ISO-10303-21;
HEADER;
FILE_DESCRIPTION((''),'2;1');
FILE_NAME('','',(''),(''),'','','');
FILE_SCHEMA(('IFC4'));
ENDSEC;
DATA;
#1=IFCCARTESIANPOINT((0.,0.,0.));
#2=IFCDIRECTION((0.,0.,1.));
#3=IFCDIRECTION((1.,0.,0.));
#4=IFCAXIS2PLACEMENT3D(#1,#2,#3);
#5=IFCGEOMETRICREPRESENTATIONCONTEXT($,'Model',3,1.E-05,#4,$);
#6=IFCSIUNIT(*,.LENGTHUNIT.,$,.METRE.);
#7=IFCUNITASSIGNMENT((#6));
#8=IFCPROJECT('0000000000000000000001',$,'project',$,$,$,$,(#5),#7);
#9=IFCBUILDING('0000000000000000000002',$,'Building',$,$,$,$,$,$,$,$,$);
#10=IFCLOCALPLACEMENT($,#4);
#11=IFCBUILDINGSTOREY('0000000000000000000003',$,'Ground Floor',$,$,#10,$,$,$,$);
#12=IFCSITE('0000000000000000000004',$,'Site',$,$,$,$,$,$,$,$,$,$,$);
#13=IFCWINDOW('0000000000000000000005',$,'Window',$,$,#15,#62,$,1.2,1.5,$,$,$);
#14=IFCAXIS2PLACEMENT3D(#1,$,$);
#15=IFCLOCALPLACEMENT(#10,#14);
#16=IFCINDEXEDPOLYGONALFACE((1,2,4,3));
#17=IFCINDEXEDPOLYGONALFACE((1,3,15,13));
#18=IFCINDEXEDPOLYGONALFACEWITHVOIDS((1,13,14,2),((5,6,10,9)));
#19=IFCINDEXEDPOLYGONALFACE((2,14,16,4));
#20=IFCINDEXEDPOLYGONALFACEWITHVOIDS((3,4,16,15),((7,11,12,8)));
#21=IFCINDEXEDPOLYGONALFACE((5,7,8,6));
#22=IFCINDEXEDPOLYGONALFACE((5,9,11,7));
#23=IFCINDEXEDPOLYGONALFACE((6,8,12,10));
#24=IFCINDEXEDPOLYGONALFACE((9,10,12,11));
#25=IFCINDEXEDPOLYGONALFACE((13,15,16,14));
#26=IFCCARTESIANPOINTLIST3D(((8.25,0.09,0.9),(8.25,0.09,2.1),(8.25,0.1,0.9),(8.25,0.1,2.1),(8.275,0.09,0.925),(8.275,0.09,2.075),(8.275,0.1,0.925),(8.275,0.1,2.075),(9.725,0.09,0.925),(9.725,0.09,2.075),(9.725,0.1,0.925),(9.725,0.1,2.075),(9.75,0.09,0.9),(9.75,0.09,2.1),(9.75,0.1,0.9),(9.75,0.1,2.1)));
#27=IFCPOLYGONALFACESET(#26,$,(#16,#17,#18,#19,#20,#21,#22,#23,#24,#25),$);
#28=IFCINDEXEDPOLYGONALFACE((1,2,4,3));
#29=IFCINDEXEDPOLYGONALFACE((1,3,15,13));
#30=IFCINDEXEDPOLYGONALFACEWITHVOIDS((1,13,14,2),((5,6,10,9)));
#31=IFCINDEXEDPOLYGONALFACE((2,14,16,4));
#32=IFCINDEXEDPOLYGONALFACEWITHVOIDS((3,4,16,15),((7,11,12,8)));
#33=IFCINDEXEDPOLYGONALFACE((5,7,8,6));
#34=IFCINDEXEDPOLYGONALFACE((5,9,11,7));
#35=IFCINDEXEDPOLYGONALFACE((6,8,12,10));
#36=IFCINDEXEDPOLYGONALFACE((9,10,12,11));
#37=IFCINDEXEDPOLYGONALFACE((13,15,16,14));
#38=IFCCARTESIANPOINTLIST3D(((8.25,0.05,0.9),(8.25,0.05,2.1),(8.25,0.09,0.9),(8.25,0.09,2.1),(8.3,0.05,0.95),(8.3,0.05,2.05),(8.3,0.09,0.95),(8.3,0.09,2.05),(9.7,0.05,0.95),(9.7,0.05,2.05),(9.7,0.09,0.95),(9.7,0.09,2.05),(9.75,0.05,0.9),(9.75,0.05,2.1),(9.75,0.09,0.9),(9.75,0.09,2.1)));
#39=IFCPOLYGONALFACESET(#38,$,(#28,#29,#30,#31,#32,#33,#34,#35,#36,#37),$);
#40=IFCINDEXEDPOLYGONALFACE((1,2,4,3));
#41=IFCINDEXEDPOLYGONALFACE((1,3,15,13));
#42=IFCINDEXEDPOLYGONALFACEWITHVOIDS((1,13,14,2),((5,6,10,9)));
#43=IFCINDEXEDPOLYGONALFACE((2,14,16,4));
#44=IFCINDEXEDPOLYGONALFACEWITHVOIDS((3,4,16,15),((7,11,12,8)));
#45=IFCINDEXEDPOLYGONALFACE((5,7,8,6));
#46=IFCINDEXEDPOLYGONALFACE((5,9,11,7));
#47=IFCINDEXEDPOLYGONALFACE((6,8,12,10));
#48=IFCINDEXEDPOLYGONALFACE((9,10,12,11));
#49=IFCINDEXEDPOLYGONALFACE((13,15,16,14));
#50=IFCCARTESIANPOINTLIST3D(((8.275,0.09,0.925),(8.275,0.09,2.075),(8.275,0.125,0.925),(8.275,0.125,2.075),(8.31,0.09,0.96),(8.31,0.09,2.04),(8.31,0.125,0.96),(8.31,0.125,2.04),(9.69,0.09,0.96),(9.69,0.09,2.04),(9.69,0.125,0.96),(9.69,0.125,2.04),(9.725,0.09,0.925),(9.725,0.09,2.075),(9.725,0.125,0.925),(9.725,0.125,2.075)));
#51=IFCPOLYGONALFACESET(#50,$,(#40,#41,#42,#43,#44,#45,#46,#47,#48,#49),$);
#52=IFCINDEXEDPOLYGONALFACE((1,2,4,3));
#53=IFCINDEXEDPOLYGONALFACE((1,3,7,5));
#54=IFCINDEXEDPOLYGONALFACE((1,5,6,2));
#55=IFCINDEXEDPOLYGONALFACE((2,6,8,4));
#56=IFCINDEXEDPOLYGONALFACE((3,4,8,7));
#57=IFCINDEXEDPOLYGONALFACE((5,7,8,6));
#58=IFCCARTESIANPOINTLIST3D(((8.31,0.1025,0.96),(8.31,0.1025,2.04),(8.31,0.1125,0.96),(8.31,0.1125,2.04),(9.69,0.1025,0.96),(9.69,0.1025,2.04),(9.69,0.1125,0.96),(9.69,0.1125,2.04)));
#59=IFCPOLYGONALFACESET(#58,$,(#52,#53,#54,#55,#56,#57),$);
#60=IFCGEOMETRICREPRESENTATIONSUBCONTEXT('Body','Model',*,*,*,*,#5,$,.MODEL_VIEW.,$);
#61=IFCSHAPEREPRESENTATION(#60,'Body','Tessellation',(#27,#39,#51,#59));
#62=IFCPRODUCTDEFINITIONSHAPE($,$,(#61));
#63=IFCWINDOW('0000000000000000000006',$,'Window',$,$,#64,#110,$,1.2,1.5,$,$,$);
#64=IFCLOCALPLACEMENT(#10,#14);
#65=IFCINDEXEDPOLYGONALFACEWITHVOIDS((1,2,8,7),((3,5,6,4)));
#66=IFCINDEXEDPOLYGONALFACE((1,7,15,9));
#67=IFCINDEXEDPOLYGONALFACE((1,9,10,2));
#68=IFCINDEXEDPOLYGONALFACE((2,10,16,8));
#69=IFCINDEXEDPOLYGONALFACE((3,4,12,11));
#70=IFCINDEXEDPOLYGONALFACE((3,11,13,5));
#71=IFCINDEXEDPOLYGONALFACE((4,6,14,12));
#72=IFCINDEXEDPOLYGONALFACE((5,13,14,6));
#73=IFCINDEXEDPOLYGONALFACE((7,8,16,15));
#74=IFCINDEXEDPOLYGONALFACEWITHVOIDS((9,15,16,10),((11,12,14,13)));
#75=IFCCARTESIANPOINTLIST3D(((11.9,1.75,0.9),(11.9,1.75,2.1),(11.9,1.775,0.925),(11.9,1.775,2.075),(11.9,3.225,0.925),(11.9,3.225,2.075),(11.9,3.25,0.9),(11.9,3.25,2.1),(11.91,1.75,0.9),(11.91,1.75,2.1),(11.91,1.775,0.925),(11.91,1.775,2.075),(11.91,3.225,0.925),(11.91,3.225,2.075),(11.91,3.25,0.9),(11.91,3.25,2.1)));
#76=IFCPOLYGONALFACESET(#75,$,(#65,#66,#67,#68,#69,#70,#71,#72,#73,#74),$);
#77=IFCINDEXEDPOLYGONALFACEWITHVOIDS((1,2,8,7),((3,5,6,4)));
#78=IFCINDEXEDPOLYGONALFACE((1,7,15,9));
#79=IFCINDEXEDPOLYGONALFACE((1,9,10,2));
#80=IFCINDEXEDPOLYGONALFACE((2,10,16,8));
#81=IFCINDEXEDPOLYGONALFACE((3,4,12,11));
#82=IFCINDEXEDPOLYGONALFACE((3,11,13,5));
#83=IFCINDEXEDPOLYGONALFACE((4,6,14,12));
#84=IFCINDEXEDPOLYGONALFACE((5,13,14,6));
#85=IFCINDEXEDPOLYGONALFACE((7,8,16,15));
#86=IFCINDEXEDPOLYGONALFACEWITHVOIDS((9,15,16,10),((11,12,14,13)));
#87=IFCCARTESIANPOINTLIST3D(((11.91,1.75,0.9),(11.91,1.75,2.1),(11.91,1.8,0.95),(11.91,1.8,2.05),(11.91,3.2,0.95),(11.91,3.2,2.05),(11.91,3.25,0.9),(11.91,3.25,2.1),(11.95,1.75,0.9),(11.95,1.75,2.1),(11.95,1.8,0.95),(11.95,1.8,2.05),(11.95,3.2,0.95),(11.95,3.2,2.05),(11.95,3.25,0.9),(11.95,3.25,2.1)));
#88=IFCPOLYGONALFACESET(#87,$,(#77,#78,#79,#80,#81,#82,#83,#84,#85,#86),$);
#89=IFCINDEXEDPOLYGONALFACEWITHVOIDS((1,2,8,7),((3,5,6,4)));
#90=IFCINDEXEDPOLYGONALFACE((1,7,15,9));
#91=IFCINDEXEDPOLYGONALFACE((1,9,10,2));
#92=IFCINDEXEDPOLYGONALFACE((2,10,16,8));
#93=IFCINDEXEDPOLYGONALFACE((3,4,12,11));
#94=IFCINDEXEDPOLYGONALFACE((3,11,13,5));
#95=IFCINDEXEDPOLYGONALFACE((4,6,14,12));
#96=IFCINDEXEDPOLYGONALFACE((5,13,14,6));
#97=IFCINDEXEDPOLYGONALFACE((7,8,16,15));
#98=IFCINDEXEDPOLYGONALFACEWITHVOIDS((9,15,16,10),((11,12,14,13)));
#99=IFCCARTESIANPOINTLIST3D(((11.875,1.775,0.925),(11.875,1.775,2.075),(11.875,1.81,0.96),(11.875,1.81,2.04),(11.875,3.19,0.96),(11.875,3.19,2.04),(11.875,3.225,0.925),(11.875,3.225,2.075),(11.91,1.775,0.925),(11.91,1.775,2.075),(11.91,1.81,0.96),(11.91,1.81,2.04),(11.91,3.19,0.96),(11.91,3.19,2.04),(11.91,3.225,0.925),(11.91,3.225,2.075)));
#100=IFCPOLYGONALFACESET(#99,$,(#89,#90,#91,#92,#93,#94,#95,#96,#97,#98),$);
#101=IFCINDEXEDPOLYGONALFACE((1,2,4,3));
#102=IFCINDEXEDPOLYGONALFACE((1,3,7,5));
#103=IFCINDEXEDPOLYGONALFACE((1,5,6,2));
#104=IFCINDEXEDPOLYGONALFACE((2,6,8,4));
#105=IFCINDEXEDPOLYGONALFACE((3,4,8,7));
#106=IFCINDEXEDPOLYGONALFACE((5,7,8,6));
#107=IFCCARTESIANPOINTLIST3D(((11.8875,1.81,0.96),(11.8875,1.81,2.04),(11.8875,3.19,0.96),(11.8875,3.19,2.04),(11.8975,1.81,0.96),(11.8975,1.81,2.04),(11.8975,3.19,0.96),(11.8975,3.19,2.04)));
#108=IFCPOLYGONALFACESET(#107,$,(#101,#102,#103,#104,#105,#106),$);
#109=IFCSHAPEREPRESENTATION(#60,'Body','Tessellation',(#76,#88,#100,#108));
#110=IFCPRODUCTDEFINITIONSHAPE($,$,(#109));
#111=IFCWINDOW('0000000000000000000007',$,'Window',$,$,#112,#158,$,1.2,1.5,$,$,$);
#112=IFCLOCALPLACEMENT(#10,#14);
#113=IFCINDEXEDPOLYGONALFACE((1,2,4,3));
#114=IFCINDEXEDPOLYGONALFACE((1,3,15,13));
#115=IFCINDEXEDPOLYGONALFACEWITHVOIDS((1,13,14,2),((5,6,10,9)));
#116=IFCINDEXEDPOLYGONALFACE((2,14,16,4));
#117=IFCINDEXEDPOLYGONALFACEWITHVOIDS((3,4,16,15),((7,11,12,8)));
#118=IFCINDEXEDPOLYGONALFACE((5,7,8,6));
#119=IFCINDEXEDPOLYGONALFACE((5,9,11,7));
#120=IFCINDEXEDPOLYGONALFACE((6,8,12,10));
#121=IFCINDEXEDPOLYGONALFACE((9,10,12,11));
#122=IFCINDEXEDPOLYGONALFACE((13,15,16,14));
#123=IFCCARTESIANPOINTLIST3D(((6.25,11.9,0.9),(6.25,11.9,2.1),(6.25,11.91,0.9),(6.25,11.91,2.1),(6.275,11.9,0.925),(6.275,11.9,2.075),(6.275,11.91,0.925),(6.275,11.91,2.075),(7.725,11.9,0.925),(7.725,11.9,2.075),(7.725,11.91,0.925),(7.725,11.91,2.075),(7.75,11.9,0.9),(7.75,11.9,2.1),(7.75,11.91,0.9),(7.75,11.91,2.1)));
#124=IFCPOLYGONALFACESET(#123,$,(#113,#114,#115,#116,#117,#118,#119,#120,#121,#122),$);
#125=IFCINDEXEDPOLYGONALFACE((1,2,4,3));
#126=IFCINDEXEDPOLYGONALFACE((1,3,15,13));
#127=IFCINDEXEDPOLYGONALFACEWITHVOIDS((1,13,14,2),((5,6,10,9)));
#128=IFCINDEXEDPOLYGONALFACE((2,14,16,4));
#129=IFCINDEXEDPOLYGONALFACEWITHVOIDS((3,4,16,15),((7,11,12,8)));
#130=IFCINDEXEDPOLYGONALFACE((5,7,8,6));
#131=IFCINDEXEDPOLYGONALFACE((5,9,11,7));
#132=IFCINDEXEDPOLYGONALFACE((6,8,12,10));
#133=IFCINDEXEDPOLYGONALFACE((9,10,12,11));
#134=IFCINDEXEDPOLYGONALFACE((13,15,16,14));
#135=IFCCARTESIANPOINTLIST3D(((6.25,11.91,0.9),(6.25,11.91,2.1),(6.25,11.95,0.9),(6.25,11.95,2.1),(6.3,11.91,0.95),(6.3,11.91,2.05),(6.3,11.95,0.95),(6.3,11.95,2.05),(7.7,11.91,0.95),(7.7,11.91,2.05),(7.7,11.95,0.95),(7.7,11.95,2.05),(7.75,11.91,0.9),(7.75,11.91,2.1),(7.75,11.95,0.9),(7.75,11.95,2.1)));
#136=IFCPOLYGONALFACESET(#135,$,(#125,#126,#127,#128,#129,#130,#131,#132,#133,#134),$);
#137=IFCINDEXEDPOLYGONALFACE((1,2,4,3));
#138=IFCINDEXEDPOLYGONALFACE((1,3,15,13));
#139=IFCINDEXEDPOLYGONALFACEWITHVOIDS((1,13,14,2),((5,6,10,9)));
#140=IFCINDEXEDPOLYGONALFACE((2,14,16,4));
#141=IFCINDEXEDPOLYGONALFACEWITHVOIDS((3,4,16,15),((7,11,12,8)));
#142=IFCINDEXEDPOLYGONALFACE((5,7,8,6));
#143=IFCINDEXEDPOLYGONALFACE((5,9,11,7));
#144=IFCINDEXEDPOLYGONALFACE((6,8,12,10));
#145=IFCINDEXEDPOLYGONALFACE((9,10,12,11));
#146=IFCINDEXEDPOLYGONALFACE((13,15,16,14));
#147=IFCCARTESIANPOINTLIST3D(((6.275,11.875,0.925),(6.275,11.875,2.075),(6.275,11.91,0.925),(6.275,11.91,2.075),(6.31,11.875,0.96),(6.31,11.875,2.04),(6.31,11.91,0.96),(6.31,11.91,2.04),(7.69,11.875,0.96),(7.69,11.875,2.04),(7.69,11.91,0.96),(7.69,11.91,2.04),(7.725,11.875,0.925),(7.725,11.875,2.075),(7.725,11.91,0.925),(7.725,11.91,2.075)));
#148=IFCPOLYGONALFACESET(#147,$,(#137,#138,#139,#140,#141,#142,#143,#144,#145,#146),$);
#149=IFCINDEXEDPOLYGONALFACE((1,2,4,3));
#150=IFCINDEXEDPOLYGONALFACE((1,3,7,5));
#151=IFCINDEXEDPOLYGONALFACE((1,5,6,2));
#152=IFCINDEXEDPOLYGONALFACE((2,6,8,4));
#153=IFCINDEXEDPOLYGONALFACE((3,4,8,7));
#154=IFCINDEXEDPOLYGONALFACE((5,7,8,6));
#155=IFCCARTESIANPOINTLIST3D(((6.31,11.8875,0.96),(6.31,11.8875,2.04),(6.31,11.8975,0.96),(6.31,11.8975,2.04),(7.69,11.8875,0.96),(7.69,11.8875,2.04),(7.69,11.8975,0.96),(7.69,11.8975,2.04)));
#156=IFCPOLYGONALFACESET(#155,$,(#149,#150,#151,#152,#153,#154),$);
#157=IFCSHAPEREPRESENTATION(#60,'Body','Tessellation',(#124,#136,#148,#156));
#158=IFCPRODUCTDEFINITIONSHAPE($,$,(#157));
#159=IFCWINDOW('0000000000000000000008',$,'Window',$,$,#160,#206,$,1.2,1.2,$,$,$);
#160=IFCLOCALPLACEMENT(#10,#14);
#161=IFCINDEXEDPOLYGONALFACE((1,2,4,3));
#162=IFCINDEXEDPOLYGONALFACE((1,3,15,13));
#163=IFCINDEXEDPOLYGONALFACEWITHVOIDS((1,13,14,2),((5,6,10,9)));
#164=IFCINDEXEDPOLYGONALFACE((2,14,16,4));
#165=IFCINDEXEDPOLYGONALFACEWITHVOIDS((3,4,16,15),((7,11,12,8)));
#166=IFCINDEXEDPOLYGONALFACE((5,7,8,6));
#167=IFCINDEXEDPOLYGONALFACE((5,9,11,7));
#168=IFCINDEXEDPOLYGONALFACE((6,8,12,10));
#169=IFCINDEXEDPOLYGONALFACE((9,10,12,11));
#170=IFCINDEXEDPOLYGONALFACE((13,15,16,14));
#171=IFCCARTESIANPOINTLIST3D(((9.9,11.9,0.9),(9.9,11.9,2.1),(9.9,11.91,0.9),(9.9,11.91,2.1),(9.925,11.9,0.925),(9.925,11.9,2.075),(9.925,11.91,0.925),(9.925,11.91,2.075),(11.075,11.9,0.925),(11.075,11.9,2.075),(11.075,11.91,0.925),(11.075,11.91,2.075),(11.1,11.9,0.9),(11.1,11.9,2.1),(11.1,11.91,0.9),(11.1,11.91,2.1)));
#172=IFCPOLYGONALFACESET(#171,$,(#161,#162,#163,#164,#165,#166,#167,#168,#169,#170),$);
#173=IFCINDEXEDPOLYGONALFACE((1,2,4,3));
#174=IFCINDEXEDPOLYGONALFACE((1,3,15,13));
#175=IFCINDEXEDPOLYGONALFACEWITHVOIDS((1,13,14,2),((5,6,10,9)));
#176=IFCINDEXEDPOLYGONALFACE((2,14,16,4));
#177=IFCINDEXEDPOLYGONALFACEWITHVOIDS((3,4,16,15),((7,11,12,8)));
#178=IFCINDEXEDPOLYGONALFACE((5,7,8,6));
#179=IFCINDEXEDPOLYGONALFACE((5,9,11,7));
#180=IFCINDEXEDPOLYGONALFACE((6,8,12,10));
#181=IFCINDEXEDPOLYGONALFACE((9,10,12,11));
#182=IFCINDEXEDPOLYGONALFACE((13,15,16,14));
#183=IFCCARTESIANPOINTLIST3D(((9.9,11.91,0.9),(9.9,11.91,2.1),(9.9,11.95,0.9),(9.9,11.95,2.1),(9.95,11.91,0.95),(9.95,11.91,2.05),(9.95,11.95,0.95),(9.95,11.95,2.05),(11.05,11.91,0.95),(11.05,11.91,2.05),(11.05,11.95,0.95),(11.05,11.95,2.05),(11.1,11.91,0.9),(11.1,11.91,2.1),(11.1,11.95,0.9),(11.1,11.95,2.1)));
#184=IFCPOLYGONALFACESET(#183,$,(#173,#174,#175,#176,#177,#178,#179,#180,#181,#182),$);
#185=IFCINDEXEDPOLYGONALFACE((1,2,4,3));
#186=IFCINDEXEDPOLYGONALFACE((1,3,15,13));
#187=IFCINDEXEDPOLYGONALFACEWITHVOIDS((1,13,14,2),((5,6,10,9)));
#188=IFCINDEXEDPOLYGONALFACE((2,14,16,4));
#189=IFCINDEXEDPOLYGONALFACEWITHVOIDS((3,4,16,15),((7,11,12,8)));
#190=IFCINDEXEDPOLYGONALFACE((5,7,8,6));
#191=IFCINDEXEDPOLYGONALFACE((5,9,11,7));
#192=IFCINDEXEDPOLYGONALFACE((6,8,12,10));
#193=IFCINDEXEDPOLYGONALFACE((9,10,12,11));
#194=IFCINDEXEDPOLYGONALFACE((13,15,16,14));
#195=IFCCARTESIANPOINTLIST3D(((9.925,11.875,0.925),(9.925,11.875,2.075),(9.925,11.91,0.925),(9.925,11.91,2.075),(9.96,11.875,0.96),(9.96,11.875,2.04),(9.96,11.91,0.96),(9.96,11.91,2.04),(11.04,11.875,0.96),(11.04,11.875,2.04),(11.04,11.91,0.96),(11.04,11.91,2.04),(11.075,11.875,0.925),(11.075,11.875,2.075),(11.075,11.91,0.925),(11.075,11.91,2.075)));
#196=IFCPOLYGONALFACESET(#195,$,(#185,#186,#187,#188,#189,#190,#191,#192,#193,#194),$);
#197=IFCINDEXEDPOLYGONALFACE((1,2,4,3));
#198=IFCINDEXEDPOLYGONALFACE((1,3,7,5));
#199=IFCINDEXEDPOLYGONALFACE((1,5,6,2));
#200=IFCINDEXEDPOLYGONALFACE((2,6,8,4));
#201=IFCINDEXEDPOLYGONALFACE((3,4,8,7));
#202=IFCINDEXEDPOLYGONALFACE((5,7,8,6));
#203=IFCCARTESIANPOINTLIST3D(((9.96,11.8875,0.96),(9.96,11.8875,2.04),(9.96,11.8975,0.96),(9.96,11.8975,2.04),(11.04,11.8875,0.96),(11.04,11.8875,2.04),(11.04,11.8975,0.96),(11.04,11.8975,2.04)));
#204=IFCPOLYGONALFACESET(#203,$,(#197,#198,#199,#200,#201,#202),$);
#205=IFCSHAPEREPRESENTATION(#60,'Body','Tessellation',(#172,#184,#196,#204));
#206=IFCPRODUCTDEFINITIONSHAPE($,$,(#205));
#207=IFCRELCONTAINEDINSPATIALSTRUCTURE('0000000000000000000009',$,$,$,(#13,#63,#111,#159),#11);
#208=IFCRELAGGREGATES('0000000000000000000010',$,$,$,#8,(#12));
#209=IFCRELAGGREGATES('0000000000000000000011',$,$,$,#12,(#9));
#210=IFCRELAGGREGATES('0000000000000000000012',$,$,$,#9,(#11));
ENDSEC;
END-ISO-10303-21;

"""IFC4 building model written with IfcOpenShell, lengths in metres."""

from ifc_helpers import new_model, si_unit, frame, origin_with_axes, place, context, subcontext, project, spatial, line, indexed_curve, outline, extrude, element, save


model = new_model("IFC4")

# Units and contexts
model_context = context("Model", 3, precision=1e-05, world=origin_with_axes())
body_context = subcontext(model_context, "Body", "Model", "MODEL_VIEW")
ifc_project = project(units=[si_unit("LENGTHUNIT", "METRE")], contexts=[model_context])

# Site, building, storey
site = spatial("IfcSite", under=ifc_project, Name="Site")
building = spatial("IfcBuilding", under=site, Name="Building")
storey_placement = place(None, origin_with_axes())
storey = spatial("IfcBuildingStorey", under=building, at=storey_placement, Name="Ground Floor")

# Windows
for number, where, z_axis, x_axis, name in (
    (1, (8.25, 0.0, 0.9), (0.0, 0.0, 1.0), (1.0, 0.0, 0.0), "Window"),
    (2, (12.0, 1.75, 0.9), (0.0, 0.0, 1.0), (0.0, 1.0, 0.0), "Window"),
    (3, (7.75, 12.0, 0.9), (0.0, 0.0, 1.0), (-1.0, 0.0, 0.0), "Window"),
):
    element("IfcWindow", number, at=place(storey_placement, frame(where, z_axis=z_axis, x_axis=x_axis)), inside=storey, Name=name, OverallHeight=1.2, OverallWidth=1.5, context=body_context, shape_type="SweptSolid", body=[
        extrude(outline(indexed_curve([(0.0, 0.0), (1.5, 0.0), (1.5, 1.2), (0.0, 1.2)], segments=[line(1, 2, 3, 4, 1)]), holes=[indexed_curve([(0.025, 0.025), (1.475, 0.025), (1.475, 1.175), (0.025, 1.175)], segments=[line(1, 2, 3, 4, 1)])]), frame((0.0, 0.09, 0.0), z_axis=(0.0, -1.0, 0.0), x_axis=(1.0, 0.0, 0.0)), (0.0, 0.0, -1.0), 0.01),
        extrude(outline(indexed_curve([(0.0, 0.0), (1.5, 0.0), (1.5, 1.2), (0.0, 1.2)], segments=[line(1, 2, 3, 4, 1)]), holes=[indexed_curve([(0.05, 0.05), (1.45, 0.05), (1.45, 1.15), (0.05, 1.15)], segments=[line(1, 2, 3, 4, 1)])]), frame((0.0, 0.05, 0.0), z_axis=(0.0, -1.0, 0.0), x_axis=(1.0, 0.0, 0.0)), (0.0, 0.0, -1.0), 0.04),
        extrude(outline(indexed_curve([(0.0, 0.0), (1.45, 0.0), (1.45, 1.15), (0.0, 1.15)], segments=[line(1, 2, 3, 4, 1)]), holes=[indexed_curve([(0.035, 0.035), (1.415, 0.035), (1.415, 1.115), (0.035, 1.115)], segments=[line(1, 2, 3, 4, 1)])]), frame((0.025, 0.09, 0.025), z_axis=(0.0, -1.0, 0.0), x_axis=(1.0, 0.0, 0.0)), (0.0, 0.0, -1.0), 0.035),
        extrude(outline(indexed_curve([(0.035, 0.035), (1.415, 0.035), (1.415, 1.115), (0.035, 1.115)], segments=[line(1, 2, 3, 4, 1)])), frame((0.025, 0.1025, 0.025), z_axis=(0.0, -1.0, 0.0), x_axis=(1.0, 0.0, 0.0)), (0.0, 0.0, -1.0), 0.01),
    ])
for number, where, z_axis, x_axis, name in (
    (4, (11.1, 12.0, 0.9), (0.0, 0.0, 1.0), (-1.0, 0.0, 0.0), "Window"),
):
    element("IfcWindow", number, at=place(storey_placement, frame(where, z_axis=z_axis, x_axis=x_axis)), inside=storey, Name=name, OverallHeight=1.2, OverallWidth=1.2, context=body_context, shape_type="SweptSolid", body=[
        extrude(outline(indexed_curve([(0.0, 0.0), (1.2, 0.0), (1.2, 1.2), (0.0, 1.2)], segments=[line(1, 2, 3, 4, 1)]), holes=[indexed_curve([(0.025, 0.025), (1.175, 0.025), (1.175, 1.175), (0.025, 1.175)], segments=[line(1, 2, 3, 4, 1)])]), frame((0.0, 0.09, 0.0), z_axis=(0.0, -1.0, 0.0), x_axis=(1.0, 0.0, 0.0)), (0.0, 0.0, -1.0), 0.01),
        extrude(outline(indexed_curve([(0.0, 0.0), (1.2, 0.0), (1.2, 1.2), (0.0, 1.2)], segments=[line(1, 2, 3, 4, 1)]), holes=[indexed_curve([(0.05, 0.05), (1.15, 0.05), (1.15, 1.15), (0.05, 1.15)], segments=[line(1, 2, 3, 4, 1)])]), frame((0.0, 0.05, 0.0), z_axis=(0.0, -1.0, 0.0), x_axis=(1.0, 0.0, 0.0)), (0.0, 0.0, -1.0), 0.04),
        extrude(outline(indexed_curve([(0.0, 0.0), (1.15, 0.0), (1.15, 1.15), (0.0, 1.15)], segments=[line(1, 2, 3, 4, 1)]), holes=[indexed_curve([(0.035, 0.035), (1.115, 0.035), (1.115, 1.115), (0.035, 1.115)], segments=[line(1, 2, 3, 4, 1)])]), frame((0.025, 0.09, 0.025), z_axis=(0.0, -1.0, 0.0), x_axis=(1.0, 0.0, 0.0)), (0.0, 0.0, -1.0), 0.035),
        extrude(outline(indexed_curve([(0.035, 0.035), (1.115, 0.035), (1.115, 1.115), (0.035, 1.115)], segments=[line(1, 2, 3, 4, 1)])), frame((0.025, 0.1025, 0.025), z_axis=(0.0, -1.0, 0.0), x_axis=(1.0, 0.0, 0.0)), (0.0, 0.0, -1.0), 0.01),
    ])

save(model, "model.ifc")
